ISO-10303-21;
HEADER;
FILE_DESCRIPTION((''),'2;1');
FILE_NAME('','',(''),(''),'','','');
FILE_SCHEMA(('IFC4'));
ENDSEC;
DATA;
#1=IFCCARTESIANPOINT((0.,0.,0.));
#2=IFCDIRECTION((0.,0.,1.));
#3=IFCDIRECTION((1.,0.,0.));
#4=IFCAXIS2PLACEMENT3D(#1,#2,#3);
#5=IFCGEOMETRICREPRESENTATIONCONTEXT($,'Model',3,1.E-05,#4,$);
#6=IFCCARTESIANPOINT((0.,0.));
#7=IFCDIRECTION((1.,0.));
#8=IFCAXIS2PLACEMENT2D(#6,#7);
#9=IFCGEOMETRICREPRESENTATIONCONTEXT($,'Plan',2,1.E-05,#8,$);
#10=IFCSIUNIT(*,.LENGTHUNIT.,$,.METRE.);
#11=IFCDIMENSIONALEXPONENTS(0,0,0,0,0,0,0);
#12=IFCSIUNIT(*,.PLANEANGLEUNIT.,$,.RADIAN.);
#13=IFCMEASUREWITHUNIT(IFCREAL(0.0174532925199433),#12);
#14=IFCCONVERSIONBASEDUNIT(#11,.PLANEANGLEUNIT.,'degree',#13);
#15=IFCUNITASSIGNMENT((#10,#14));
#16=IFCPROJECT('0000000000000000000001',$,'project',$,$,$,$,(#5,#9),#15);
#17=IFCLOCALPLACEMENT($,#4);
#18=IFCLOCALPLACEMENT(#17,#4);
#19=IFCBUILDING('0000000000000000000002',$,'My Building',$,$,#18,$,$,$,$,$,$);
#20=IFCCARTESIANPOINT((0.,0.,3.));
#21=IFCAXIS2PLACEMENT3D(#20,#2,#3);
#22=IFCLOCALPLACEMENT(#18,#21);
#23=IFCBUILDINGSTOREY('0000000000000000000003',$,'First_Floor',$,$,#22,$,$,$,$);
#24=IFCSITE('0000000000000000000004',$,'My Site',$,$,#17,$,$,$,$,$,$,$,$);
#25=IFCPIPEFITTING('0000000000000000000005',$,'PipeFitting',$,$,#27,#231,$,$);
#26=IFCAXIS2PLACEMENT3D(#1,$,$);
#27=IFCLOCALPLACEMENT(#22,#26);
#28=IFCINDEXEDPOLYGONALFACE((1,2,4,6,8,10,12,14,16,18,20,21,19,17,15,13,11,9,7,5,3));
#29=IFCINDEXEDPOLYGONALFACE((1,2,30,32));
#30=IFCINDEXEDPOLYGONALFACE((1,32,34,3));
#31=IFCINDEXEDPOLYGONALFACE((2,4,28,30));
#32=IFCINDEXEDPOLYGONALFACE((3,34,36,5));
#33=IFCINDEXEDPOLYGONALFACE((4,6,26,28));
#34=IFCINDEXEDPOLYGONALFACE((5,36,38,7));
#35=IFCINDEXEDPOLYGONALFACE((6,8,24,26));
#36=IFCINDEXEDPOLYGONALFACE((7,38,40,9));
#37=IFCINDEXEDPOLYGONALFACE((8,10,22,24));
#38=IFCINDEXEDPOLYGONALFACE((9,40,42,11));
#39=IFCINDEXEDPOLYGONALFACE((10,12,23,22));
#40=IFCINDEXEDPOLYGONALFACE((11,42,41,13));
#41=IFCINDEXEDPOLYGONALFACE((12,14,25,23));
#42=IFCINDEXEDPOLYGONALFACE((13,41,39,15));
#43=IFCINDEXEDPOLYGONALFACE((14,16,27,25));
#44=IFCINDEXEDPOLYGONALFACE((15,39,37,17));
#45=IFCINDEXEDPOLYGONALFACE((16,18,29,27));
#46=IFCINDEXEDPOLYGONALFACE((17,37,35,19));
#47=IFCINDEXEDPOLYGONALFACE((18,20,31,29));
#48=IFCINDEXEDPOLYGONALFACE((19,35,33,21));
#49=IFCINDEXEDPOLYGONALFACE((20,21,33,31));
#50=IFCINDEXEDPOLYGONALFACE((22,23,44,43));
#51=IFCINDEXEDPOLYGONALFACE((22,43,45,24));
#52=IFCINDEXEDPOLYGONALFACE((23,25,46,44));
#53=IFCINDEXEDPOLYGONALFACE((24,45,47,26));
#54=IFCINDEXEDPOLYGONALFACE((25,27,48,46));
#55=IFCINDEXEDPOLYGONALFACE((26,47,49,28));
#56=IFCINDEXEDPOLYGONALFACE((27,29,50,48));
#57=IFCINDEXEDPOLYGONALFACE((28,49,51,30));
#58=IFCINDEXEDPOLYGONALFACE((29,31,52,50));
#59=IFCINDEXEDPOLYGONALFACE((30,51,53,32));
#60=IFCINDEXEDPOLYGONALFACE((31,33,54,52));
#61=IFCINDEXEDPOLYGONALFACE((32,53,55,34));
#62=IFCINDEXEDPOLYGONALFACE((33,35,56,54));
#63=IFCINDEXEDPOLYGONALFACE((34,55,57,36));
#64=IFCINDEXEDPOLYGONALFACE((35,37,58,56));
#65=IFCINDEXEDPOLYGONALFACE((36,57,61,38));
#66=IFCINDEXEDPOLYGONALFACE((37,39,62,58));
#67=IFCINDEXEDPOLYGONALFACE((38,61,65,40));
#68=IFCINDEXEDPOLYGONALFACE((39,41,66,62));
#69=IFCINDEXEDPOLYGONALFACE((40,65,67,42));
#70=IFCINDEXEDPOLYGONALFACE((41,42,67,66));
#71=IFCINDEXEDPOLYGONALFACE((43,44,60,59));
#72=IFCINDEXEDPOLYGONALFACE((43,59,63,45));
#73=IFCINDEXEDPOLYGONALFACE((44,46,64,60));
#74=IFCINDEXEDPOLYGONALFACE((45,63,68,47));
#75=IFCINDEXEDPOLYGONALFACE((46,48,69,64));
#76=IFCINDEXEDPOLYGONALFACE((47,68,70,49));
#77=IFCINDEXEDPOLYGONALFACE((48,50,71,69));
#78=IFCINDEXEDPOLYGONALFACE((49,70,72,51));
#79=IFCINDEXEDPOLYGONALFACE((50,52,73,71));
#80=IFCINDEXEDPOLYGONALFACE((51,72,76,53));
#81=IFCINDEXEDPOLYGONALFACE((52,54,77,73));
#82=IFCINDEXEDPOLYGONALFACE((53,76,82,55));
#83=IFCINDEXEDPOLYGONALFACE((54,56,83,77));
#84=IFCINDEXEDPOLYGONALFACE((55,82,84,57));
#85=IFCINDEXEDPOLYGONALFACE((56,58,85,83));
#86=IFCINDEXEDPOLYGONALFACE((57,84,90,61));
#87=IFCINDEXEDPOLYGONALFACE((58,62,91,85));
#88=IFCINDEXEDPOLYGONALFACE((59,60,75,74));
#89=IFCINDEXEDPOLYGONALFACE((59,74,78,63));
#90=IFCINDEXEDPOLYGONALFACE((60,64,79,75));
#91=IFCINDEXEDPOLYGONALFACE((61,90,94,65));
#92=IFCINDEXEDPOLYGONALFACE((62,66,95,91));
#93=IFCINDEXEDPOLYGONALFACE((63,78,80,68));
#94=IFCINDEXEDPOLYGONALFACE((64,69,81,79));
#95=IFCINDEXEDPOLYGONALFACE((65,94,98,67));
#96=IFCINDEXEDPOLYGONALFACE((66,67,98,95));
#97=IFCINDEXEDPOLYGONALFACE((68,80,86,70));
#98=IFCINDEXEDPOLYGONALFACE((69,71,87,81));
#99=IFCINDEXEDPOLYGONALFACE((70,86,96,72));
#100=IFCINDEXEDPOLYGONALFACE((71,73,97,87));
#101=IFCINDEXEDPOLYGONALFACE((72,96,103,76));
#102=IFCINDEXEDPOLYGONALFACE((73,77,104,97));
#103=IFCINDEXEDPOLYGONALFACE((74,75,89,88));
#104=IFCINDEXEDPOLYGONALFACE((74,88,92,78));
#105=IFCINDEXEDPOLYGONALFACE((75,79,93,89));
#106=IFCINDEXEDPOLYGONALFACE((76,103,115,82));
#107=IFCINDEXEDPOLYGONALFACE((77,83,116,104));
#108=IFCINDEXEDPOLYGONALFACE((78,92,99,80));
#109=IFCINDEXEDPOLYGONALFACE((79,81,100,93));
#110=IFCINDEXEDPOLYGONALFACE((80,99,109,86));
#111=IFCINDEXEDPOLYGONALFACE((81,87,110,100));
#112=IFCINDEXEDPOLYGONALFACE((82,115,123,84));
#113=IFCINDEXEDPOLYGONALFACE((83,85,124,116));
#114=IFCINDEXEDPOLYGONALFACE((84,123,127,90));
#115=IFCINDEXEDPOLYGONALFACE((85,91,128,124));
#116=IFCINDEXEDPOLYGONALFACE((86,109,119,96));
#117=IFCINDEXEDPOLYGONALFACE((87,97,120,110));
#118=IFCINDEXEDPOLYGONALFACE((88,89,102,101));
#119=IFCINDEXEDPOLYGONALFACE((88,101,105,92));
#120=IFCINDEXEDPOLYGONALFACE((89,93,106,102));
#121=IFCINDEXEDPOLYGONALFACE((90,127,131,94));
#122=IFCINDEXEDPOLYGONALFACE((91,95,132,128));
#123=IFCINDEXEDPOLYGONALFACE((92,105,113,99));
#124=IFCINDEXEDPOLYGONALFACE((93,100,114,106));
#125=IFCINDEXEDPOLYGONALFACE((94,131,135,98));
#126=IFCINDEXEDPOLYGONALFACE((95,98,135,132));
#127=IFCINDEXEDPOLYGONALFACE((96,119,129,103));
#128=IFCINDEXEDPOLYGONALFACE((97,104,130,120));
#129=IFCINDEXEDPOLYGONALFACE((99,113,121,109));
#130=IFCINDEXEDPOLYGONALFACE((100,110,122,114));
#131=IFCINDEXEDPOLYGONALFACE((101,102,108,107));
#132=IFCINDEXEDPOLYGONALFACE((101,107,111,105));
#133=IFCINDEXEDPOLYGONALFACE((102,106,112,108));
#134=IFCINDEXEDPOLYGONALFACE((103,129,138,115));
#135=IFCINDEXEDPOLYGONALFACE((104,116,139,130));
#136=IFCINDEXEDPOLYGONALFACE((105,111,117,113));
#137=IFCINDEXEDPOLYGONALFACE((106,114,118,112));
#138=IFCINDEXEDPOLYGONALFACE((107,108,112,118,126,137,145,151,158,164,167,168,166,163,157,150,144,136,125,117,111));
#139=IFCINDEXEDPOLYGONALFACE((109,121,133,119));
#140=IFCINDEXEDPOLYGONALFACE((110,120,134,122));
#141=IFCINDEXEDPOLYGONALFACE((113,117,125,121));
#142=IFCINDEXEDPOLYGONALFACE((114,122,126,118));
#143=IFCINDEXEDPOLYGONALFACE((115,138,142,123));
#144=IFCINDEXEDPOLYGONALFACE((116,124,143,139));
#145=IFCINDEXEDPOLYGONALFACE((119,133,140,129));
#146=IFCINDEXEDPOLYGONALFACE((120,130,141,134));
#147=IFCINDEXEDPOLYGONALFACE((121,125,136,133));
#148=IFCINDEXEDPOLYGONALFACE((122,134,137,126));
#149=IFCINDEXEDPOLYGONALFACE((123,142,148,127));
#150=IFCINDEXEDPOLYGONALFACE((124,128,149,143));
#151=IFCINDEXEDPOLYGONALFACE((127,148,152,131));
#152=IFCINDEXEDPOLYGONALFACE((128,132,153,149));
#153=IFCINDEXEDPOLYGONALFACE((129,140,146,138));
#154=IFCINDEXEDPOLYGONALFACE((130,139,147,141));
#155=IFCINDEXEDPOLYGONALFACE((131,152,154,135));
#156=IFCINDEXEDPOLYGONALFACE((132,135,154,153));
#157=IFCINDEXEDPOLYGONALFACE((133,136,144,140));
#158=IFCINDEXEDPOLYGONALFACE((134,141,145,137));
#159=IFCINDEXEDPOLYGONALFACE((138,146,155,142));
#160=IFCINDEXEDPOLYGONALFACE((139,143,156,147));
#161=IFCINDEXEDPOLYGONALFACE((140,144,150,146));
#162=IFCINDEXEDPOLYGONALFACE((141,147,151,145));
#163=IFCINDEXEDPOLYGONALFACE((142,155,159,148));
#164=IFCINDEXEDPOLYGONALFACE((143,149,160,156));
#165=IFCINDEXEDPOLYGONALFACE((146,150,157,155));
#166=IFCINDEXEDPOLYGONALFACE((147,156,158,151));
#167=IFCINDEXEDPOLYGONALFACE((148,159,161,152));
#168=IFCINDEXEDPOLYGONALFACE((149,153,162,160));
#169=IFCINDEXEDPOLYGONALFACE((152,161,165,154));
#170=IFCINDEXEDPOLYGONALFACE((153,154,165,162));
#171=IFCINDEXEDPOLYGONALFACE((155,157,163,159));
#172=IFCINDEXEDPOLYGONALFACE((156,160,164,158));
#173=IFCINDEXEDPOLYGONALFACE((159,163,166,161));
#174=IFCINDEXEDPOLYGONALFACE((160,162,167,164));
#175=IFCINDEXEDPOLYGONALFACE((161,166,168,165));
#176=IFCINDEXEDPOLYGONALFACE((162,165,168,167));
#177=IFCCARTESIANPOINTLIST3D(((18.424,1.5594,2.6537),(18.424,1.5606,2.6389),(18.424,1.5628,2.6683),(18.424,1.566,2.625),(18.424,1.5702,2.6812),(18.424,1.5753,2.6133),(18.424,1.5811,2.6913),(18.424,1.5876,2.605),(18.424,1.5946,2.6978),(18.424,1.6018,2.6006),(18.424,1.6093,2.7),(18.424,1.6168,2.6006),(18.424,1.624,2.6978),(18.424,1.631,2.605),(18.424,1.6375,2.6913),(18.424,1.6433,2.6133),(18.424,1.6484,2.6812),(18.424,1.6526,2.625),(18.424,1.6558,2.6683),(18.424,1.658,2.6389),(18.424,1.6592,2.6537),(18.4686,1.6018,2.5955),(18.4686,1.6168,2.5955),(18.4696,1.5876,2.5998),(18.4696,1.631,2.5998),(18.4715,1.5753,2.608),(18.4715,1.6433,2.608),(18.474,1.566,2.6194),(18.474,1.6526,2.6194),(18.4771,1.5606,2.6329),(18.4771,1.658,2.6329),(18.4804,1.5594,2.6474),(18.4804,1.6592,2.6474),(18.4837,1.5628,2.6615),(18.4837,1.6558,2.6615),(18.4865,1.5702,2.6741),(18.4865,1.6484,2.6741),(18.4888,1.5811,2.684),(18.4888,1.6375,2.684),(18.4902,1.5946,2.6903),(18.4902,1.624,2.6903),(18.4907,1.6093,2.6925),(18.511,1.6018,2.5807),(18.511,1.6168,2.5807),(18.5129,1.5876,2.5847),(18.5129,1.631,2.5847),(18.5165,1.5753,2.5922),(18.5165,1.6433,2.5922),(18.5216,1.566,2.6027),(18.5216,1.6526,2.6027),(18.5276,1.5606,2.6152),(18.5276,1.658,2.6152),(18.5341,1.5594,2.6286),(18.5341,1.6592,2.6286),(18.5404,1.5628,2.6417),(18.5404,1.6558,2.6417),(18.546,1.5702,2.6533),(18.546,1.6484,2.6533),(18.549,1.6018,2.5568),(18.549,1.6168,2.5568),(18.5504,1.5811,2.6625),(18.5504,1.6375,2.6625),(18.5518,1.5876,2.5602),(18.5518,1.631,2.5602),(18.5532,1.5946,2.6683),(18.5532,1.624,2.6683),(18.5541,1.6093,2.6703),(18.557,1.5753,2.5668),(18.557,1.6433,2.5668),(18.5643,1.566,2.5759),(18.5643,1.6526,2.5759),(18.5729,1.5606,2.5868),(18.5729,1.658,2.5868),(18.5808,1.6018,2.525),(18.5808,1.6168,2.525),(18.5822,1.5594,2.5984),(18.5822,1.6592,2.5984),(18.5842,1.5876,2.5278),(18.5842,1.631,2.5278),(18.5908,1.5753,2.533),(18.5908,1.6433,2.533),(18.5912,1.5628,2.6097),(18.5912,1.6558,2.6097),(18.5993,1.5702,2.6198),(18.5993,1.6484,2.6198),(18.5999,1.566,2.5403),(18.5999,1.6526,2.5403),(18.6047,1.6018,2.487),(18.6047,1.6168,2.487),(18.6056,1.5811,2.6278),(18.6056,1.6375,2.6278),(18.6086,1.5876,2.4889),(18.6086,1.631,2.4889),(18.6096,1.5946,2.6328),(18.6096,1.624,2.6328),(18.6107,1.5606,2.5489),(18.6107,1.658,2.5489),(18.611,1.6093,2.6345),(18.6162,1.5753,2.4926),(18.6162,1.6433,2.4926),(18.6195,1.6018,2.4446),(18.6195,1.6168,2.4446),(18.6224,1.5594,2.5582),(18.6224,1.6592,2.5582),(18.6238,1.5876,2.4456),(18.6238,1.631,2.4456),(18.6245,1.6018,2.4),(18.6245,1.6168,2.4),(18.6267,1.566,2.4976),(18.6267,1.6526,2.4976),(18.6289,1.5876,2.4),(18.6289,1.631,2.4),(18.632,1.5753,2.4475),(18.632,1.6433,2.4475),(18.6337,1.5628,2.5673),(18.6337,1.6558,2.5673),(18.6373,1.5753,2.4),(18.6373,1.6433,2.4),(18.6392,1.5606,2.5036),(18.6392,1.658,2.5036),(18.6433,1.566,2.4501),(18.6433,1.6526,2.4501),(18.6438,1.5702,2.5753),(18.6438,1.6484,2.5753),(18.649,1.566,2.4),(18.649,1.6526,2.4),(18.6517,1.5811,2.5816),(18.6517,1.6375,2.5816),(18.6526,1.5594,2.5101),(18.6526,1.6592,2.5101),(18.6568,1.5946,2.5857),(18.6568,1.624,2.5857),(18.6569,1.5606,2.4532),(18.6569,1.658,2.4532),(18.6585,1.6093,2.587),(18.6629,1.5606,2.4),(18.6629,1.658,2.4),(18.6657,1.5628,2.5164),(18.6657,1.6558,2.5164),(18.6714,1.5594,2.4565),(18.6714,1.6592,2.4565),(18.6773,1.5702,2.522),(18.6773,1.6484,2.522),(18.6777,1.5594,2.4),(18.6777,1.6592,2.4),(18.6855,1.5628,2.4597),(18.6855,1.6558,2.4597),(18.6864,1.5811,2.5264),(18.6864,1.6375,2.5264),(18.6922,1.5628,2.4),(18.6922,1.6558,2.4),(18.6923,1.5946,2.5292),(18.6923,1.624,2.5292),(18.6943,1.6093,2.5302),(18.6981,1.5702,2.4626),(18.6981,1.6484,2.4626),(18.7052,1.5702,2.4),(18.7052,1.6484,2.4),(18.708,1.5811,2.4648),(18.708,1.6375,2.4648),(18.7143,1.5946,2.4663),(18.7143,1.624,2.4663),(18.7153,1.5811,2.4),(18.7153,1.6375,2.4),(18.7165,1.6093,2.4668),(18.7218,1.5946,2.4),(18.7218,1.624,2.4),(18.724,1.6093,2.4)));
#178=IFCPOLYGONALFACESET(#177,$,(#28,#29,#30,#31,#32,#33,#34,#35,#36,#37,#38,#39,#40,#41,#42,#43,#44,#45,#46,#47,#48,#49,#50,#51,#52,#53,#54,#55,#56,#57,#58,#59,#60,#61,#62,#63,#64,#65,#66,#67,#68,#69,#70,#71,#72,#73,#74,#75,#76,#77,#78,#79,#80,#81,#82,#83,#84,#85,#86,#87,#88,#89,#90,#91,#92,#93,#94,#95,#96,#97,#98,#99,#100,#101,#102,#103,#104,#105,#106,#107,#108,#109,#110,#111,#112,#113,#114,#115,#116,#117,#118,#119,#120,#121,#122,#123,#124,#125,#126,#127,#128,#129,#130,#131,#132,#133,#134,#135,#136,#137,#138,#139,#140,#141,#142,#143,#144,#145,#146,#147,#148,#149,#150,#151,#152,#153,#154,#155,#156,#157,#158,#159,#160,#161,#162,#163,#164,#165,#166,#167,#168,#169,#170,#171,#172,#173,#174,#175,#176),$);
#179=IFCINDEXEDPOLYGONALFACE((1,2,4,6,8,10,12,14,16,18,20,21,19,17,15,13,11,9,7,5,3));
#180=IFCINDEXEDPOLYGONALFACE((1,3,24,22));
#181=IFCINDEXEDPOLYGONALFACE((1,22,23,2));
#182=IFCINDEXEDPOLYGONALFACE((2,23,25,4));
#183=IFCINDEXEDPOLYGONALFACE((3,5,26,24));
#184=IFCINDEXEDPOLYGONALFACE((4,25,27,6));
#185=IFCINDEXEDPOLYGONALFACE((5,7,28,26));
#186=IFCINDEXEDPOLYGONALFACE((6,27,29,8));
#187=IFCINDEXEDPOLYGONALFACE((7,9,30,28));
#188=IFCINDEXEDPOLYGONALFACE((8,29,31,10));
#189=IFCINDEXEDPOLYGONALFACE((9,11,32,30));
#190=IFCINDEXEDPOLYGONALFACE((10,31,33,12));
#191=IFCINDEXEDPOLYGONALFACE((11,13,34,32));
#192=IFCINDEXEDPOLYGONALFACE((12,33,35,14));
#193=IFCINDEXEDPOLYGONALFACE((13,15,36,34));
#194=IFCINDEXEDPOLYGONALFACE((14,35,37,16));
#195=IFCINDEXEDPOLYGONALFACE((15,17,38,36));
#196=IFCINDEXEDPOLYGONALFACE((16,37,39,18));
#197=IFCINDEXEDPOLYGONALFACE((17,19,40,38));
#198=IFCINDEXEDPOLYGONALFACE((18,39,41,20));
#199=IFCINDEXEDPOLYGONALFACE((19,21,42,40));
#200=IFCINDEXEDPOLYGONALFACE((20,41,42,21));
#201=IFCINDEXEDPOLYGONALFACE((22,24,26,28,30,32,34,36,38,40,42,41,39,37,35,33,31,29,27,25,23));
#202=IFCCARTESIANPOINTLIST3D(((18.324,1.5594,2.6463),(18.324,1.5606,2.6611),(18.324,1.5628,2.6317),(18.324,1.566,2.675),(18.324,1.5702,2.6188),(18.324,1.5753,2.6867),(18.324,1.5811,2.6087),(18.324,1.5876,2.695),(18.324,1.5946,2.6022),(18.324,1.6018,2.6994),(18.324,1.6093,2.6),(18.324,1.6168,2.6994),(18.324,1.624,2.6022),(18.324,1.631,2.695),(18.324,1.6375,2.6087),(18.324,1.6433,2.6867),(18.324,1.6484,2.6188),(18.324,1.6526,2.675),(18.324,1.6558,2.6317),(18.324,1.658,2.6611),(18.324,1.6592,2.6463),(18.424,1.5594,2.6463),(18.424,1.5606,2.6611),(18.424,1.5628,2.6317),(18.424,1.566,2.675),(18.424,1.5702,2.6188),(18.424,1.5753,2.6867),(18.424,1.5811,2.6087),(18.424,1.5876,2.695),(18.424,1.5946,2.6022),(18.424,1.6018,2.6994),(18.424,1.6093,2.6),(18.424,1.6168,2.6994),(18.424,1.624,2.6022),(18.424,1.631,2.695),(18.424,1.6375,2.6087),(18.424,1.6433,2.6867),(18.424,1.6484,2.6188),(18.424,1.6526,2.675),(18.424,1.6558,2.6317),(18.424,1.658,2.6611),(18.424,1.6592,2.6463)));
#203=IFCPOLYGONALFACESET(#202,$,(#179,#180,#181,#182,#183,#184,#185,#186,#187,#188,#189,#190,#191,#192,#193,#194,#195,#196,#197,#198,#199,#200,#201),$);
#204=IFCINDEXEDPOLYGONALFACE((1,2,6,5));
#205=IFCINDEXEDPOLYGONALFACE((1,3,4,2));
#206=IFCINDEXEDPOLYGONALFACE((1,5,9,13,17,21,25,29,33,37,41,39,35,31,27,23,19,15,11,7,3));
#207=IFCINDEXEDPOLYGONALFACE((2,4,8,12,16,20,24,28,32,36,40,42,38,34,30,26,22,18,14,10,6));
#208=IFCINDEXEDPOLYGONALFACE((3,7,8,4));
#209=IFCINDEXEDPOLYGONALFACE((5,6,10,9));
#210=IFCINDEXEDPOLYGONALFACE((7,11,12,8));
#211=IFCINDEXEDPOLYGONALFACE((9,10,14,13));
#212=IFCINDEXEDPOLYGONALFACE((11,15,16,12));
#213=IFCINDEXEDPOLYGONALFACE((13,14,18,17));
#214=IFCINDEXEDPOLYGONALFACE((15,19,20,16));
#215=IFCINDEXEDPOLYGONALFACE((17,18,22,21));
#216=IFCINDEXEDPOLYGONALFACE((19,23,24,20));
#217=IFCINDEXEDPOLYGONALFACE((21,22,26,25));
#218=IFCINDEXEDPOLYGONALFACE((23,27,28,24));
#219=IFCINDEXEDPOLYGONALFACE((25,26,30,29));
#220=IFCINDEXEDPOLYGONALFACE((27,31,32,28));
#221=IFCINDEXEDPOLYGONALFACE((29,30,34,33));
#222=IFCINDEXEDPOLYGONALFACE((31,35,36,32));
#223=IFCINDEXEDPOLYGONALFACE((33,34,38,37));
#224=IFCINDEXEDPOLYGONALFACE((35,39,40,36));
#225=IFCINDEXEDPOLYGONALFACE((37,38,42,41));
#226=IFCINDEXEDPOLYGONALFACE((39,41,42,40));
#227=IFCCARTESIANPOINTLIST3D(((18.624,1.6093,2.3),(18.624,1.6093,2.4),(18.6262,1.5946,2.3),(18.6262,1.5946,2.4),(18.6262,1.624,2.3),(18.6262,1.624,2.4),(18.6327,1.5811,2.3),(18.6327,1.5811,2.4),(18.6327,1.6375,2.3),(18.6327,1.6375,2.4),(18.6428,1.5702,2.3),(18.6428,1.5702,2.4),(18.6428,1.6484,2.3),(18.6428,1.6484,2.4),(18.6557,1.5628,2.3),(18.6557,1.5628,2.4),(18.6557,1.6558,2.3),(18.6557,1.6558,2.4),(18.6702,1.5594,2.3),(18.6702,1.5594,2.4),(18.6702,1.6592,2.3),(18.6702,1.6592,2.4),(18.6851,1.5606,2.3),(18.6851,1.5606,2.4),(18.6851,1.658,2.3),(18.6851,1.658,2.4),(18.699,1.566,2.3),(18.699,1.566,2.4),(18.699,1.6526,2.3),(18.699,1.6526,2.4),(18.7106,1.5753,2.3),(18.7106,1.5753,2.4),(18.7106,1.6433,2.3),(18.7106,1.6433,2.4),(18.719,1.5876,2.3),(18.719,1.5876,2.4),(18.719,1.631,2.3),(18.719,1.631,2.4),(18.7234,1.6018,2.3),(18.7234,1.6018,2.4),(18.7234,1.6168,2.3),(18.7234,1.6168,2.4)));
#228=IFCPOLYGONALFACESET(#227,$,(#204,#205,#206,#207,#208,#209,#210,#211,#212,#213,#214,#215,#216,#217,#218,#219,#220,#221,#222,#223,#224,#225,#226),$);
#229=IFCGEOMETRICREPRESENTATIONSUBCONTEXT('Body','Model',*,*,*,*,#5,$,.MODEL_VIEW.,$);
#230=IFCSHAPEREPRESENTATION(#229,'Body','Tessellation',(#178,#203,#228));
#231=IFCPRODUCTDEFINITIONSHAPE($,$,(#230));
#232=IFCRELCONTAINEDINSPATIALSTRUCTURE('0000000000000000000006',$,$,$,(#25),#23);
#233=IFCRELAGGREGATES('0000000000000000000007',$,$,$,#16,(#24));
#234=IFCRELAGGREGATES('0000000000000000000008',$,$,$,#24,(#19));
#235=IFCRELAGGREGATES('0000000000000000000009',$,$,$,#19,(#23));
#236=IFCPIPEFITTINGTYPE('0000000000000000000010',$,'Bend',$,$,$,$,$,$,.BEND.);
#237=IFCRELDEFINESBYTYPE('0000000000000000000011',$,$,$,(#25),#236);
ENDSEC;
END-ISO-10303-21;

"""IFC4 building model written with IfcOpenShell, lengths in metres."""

from ifc_helpers import new_model, entity, si_unit, converted_unit, frame, origin_with_axes, origin_2d_with_axis, place, context, subcontext, project, spatial, circle, extrude, source, transform, mapped, type_object, type_shapes, element, save


model = new_model("IFC4")

# Units and contexts
model_context = context("Model", 3, precision=1e-05, world=origin_with_axes())
plan_context = context("Plan", 2, precision=1e-05, world=origin_2d_with_axis())
body_context = subcontext(model_context, "Body", "Model", "MODEL_VIEW")
ifc_project = project(units=[si_unit("LENGTHUNIT", "METRE"), converted_unit("PLANEANGLEUNIT", "degree", entity("IfcReal", 0.0174532925199433), si_unit("PLANEANGLEUNIT", "RADIAN"), dimensions=[0, 0, 0, 0, 0, 0, 0])], contexts=[model_context, plan_context])

# Site, building, storey
site_placement = place(None, origin_with_axes())
site = spatial("IfcSite", under=ifc_project, at=site_placement, Name="My Site")
building_placement = place(site_placement, origin_with_axes())
building = spatial("IfcBuilding", under=site, at=building_placement, Name="My Building")
storey_placement = place(building_placement, frame((0.0, 0.0, 3.0), z_axis=(0.0, 0.0, 1.0), x_axis=(1.0, 0.0, 0.0)))
storey = spatial("IfcBuildingStorey", under=building, at=storey_placement, Name="First_Floor")

# Pipe fitting
pipe_fitting_type = type_object("IfcPipeFittingType", Name="Bend", PredefinedType="BEND")
shared_shape_1 = source(origin_with_axes(), body_context, "Body", "SolidModel", [
    entity("IfcSweptDiskSolid", entity("IfcIndexedPolyCurve", entity("IfcCartesianPointList3D", [[0.0, 0.0, -0.1], [0.0732, 0.0, -0.2768], [0.25, 0.0, -0.35]]), [entity("IfcArcIndex", [1, 2, 3])]), 0.05),
    extrude(circle(Radius=0.05), origin_with_axes(), (0.0, 0.0, -1.0), 0.1),
    extrude(circle(Radius=0.05), frame((0.25, 0.0, -0.35), z_axis=(1.0, 0.0, 0.0), x_axis=(0.0, 0.0, 1.0)), (0.0, 0.0, 1.0), 0.1),
])
type_shapes(pipe_fitting_type, [shared_shape_1])
for number, where, z_axis, x_axis, name in (
    (1, (18.324, 1.6093, 2.65), (-1.0, 0.0, 0.0), (0.0, 0.0, -1.0), "PipeFitting"),
):
    element("IfcPipeFitting", number, at=place(storey_placement, frame(where, z_axis=z_axis, x_axis=x_axis)), inside=storey, type_object=pipe_fitting_type, Name=name, context=body_context, shape_type="MappedRepresentation", body=[
        mapped(shared_shape_1, transform((0.0, 0.0, 0.0), x_axis=(1.0, 0.0, 0.0), y_axis=(0.0, 1.0, 0.0), z_axis=(0.0, 0.0, 1.0), scale=1.0)),
    ])

save(model, "model.ifc")
